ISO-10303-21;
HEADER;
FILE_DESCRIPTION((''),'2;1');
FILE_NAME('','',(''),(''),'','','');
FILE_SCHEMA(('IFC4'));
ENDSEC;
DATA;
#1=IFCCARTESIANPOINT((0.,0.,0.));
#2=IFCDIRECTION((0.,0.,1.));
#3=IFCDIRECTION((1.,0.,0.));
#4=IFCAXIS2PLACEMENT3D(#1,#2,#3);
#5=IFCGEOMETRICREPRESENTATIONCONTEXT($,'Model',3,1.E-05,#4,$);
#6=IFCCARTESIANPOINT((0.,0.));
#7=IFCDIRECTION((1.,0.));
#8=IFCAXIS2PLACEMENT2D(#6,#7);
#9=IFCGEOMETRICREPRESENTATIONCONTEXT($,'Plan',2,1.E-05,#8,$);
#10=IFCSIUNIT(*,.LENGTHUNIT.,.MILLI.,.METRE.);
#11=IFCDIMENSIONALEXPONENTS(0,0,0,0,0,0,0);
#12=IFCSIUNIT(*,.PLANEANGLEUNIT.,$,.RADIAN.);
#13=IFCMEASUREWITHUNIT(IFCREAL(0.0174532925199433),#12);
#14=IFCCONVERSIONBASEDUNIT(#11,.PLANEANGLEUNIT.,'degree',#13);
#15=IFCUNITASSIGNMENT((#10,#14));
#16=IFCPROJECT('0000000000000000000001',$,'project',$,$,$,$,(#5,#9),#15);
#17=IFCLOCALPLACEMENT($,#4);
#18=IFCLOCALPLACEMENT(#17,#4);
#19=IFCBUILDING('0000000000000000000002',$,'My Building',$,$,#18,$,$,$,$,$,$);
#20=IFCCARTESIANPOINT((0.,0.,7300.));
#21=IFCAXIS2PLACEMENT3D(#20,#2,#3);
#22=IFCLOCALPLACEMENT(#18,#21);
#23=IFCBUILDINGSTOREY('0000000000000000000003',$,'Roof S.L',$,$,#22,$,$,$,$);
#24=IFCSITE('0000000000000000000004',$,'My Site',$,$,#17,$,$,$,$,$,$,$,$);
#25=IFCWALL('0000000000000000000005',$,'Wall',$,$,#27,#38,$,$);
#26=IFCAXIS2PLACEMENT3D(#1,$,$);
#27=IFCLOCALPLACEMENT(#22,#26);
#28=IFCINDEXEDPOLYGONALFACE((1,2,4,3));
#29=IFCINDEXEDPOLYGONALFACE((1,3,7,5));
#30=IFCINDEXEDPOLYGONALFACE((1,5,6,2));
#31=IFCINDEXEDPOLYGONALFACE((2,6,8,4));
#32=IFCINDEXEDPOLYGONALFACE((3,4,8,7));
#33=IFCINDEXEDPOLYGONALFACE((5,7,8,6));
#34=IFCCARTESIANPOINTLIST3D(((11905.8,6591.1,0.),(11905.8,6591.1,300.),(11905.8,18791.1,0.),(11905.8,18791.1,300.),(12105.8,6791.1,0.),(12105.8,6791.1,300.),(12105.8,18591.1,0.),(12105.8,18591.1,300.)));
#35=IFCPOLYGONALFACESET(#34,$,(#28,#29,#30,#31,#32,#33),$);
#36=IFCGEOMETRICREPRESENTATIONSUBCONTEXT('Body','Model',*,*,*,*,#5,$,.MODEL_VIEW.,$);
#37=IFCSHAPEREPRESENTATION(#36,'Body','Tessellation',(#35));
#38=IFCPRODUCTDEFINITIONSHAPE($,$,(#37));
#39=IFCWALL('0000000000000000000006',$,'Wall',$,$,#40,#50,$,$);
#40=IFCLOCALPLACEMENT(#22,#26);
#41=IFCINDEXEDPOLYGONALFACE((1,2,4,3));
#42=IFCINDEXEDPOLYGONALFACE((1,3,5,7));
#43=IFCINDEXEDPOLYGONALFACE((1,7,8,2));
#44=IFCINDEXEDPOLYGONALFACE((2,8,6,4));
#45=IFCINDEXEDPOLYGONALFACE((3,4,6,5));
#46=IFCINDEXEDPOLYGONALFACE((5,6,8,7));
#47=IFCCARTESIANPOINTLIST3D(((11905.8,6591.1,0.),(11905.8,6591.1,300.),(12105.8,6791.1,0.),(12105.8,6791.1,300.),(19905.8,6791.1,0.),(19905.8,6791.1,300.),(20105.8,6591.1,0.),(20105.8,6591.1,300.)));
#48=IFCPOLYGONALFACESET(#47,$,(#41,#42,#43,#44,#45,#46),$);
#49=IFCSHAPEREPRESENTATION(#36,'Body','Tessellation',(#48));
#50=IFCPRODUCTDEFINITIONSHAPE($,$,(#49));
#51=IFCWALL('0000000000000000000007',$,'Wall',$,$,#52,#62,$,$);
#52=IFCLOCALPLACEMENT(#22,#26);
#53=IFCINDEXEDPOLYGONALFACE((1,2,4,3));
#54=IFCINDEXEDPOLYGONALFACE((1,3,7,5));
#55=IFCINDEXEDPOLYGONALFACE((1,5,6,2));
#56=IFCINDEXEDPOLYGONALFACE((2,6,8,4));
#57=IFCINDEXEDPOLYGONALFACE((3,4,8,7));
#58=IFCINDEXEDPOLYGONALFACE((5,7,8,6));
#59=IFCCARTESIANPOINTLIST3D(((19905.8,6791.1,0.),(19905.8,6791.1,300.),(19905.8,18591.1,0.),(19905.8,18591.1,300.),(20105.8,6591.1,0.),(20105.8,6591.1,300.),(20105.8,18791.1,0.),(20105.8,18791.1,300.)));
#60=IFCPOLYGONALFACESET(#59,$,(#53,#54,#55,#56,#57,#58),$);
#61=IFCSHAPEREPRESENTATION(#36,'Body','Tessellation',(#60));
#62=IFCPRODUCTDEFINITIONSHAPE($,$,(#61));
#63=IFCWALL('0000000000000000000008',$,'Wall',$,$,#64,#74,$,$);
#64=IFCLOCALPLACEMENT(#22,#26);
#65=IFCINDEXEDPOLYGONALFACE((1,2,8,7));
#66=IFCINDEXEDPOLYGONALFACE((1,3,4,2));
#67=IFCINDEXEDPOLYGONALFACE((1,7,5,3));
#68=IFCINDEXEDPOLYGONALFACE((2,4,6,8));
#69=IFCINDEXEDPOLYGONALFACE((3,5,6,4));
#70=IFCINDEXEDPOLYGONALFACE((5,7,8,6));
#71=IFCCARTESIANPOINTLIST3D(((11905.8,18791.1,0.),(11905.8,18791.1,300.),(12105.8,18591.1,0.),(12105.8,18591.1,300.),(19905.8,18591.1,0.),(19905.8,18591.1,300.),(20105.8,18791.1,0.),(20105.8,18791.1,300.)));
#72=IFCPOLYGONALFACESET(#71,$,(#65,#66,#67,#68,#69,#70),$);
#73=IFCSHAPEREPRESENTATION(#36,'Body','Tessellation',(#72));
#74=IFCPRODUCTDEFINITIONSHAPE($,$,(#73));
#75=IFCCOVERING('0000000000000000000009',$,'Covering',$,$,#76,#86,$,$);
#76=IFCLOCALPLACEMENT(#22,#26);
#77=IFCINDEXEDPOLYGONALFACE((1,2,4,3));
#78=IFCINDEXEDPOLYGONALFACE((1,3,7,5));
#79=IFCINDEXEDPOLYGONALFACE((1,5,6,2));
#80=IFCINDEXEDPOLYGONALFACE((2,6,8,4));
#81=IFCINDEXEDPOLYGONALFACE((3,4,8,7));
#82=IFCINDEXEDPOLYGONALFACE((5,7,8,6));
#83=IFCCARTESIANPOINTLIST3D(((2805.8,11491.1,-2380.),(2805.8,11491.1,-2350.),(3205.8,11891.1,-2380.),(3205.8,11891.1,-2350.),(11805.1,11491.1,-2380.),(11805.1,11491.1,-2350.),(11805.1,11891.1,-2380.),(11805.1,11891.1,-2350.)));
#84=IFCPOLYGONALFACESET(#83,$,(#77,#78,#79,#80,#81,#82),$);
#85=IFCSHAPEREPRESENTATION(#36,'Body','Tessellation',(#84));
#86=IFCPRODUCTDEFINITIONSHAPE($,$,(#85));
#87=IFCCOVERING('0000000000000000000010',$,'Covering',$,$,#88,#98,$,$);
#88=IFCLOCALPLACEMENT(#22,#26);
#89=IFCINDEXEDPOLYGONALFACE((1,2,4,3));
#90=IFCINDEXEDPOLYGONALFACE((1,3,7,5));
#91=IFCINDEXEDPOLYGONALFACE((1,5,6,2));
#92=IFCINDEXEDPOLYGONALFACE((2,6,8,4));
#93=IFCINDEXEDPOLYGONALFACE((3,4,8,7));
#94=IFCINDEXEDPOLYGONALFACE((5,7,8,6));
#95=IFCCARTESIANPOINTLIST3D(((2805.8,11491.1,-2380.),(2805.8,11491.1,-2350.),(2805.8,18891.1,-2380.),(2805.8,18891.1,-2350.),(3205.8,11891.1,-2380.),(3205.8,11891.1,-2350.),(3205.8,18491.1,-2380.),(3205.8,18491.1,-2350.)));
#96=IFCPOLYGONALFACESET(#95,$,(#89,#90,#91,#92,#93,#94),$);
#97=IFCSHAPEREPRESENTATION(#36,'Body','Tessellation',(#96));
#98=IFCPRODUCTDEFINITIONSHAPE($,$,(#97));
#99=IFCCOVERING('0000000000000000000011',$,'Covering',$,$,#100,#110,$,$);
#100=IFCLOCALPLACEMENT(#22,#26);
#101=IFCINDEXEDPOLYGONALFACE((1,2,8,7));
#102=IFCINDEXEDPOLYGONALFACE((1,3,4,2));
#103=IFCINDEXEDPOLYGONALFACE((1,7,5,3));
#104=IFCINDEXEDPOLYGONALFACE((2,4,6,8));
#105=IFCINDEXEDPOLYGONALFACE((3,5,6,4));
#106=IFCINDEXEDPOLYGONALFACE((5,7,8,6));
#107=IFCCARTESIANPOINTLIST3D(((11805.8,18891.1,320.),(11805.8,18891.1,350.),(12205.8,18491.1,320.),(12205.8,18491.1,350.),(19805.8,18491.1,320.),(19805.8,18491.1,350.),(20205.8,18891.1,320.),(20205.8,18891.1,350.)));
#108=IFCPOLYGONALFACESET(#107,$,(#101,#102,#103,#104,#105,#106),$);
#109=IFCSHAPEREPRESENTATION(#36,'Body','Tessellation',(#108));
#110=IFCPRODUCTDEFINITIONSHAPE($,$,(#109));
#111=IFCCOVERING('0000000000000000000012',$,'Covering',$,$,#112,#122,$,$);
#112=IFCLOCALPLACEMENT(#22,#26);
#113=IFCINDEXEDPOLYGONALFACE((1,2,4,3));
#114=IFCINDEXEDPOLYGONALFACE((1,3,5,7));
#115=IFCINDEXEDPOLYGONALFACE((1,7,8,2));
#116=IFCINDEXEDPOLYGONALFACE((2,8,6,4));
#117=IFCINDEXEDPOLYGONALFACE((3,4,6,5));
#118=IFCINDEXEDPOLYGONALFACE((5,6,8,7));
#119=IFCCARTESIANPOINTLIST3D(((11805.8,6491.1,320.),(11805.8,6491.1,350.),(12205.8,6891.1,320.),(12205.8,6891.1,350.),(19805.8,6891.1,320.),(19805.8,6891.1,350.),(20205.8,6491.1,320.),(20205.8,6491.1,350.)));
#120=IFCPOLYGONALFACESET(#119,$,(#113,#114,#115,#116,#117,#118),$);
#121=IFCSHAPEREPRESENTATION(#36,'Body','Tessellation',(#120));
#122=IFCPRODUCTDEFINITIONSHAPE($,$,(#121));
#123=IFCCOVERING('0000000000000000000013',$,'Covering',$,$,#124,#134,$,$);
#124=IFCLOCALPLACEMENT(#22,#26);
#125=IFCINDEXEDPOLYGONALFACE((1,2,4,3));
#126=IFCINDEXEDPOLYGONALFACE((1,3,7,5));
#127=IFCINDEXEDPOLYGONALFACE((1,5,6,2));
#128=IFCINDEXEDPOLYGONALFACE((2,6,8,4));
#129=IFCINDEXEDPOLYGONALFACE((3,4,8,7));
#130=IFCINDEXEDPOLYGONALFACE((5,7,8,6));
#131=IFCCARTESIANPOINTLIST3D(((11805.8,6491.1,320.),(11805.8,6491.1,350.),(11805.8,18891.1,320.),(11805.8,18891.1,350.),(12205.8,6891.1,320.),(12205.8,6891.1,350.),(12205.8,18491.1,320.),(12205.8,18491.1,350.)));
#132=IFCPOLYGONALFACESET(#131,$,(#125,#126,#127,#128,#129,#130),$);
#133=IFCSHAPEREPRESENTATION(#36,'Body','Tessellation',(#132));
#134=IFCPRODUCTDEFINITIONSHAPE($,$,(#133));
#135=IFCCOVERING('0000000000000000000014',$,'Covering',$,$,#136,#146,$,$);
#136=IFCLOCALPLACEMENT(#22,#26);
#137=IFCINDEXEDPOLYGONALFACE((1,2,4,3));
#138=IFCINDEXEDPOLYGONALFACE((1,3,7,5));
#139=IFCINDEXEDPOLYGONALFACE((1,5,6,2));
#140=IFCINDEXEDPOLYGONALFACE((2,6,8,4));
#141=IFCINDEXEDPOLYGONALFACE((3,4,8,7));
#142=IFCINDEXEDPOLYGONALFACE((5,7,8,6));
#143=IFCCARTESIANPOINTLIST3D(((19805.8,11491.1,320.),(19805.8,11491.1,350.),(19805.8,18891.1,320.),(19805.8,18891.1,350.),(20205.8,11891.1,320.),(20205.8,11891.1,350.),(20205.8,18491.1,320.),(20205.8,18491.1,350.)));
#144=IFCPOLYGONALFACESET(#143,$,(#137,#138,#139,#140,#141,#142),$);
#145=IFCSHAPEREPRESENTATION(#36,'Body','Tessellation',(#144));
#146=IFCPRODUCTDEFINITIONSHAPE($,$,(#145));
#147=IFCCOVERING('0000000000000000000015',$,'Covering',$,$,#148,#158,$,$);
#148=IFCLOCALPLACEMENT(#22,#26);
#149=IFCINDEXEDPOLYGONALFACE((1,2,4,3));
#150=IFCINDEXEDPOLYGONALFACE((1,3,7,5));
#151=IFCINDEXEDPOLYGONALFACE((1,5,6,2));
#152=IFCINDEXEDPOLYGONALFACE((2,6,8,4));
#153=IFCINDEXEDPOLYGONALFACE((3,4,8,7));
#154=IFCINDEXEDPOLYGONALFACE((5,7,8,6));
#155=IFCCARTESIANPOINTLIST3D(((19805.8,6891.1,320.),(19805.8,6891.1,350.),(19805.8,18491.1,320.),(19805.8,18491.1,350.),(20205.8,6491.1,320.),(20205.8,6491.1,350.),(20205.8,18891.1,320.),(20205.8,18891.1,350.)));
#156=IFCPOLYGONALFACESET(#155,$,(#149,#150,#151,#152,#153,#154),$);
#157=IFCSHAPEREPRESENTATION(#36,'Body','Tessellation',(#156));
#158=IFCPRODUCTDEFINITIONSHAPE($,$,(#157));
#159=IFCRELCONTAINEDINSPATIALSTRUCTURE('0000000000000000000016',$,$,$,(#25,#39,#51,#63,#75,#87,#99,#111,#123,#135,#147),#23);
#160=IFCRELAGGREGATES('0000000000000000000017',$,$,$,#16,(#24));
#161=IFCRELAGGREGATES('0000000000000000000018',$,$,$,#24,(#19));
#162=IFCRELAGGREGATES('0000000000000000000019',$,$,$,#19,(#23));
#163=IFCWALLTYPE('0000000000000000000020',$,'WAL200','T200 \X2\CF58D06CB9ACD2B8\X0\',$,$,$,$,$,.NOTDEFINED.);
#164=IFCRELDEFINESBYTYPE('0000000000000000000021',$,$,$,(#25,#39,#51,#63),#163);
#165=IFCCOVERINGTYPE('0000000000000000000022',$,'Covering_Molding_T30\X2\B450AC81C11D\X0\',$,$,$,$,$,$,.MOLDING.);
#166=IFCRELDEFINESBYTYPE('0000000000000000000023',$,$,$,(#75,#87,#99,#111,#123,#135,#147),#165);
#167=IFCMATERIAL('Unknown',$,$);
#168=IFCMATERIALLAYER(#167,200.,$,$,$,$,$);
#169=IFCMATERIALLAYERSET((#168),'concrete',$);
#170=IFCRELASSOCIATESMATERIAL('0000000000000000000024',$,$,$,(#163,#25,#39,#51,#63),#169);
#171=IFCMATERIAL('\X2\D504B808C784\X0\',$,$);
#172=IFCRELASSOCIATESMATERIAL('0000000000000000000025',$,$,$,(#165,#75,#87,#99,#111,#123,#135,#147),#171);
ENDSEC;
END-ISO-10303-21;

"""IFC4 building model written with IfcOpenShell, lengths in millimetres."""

from ifc_helpers import new_model, entity, si_unit, converted_unit, frame, origin_with_axes, origin_2d_with_axis, place, context, subcontext, project, spatial, indexed_curve, rectangle, outline, extrude, clip, halfspace, material, layer, layer_set, layer_usage, material_profile, profile_set, profile_usage, type_object, element, save


model = new_model("IFC4")

# Units and contexts
model_context = context("Model", 3, precision=1e-05, world=origin_with_axes())
plan_context = context("Plan", 2, precision=1e-05, world=origin_2d_with_axis())
body_context = subcontext(model_context, "Body", "Model", "MODEL_VIEW")
ifc_project = project(units=[si_unit("LENGTHUNIT", "METRE", prefix="MILLI"), converted_unit("PLANEANGLEUNIT", "degree", entity("IfcReal", 0.0174532925199433), si_unit("PLANEANGLEUNIT", "RADIAN"), dimensions=[0, 0, 0, 0, 0, 0, 0])], contexts=[model_context, plan_context])

# Site, building, storey
site_placement = place(None, origin_with_axes())
site = spatial("IfcSite", under=ifc_project, at=site_placement, Name="My Site")
building_placement = place(site_placement, origin_with_axes())
building = spatial("IfcBuilding", under=site, at=building_placement, Name="My Building")
storey_placement = place(building_placement, frame((0.0, 0.0, 7300.0), z_axis=(0.0, 0.0, 1.0), x_axis=(1.0, 0.0, 0.0)))
storey = spatial("IfcBuildingStorey", under=building, at=storey_placement, Name="Roof S.L")

# Walls
ifc_material_1 = material(Name="Unknown")
ifc_layer = layer(ifc_material_1, 200.0)
ifc_layer_set = layer_set([ifc_layer], Name="concrete")
ifc_layer_usage_1 = layer_usage(ifc_layer_set, "AXIS2", "POSITIVE", 0.0)
wall_type = type_object("IfcWallType", Name="WAL200", Description="T200 콘크리트", PredefinedType="NOTDEFINED", material=ifc_layer_set)
wall_1_placement = place(storey_placement, frame((11905.8, 18791.1, 0.0), z_axis=(0.0, 0.0, 1.0), x_axis=(0.0, -1.0, 0.0)))
element("IfcWall", 1, at=wall_1_placement, inside=storey, type_object=wall_type, material=ifc_layer_usage_1, Name="Wall", context=body_context, shape_type="Clipping", body=[
    clip(clip(extrude(outline(indexed_curve([(0.0, 0.0), (0.0, 200.0), (12200.0, 200.0), (12200.0, 0.0), (0.0, 0.0)], self_intersect=False)), origin_with_axes(), (0.0, 0.0, 1.0), 300.0), halfspace(frame((12200.0, 0.0, -7300.0), z_axis=(0.707107, 0.707107, 0.0), x_axis=(0.707107, -0.707107, 0.0)), False)), halfspace(frame((0.0, 0.0, -7300.0), z_axis=(-0.707105, 0.707109, 0.0), x_axis=(0.707109, 0.707105, 0.0)), False)),
])
ifc_layer_usage_2 = layer_usage(ifc_layer_set, "AXIS2", "POSITIVE", 0.0)
wall_2_placement = place(storey_placement, frame((11905.8, 6591.1, 0.0), z_axis=(0.0, 0.0, 1.0), x_axis=(1.0, 0.0, 0.0)))
element("IfcWall", 2, at=wall_2_placement, inside=storey, type_object=wall_type, material=ifc_layer_usage_2, Name="Wall", context=body_context, shape_type="Clipping", body=[
    clip(clip(extrude(outline(indexed_curve([(0.0, 0.0), (0.0, 200.0), (8200.0, 200.0), (8200.0, 0.0), (0.0, 0.0)], self_intersect=False)), origin_with_axes(), (0.0, 0.0, 1.0), 300.0), halfspace(frame((8200.0, 0.0, -7300.0), z_axis=(0.707105, 0.707108, 0.0), x_axis=(0.707108, -0.707105, 0.0)), False)), halfspace(frame((0.0, 0.0, -7300.0), z_axis=(-0.707106, 0.707107, 0.0), x_axis=(0.707107, 0.707107, 0.0)), False)),
])
ifc_layer_usage_3 = layer_usage(ifc_layer_set, "AXIS2", "POSITIVE", 0.0)
wall_3_placement = place(storey_placement, frame((20105.8, 6591.1, 0.0), z_axis=(0.0, 0.0, 1.0), x_axis=(0.0, 1.0, 0.0)))
element("IfcWall", 3, at=wall_3_placement, inside=storey, type_object=wall_type, material=ifc_layer_usage_3, Name="Wall", context=body_context, shape_type="Clipping", body=[
    clip(clip(extrude(outline(indexed_curve([(0.0, 0.0), (0.0, 200.0), (12200.0, 200.0), (12200.0, 0.0), (0.0, 0.0)], self_intersect=False)), origin_with_axes(), (0.0, 0.0, 1.0), 300.0), halfspace(frame((12200.0, 0.0, -7300.0), z_axis=(0.707106, 0.707107, 0.0), x_axis=(0.707107, -0.707107, 0.0)), False)), halfspace(frame((0.0, 0.0, -7300.0), z_axis=(-0.707109, 0.707105, 0.0), x_axis=(0.707105, 0.707109, 0.0)), False)),
])
ifc_layer_usage_4 = layer_usage(ifc_layer_set, "AXIS2", "POSITIVE", 0.0)
wall_4_placement = place(storey_placement, frame((20105.8, 18791.1, 0.0), z_axis=(0.0, 0.0, 1.0), x_axis=(-1.0, 0.0, 0.0)))
element("IfcWall", 4, at=wall_4_placement, inside=storey, type_object=wall_type, material=ifc_layer_usage_4, Name="Wall", context=body_context, shape_type="Clipping", body=[
    clip(clip(extrude(outline(indexed_curve([(0.0, 0.0), (0.0, 200.0), (8200.0, 200.0), (8200.0, 0.0), (0.0, 0.0)], self_intersect=False)), origin_with_axes(), (0.0, 0.0, 1.0), 300.0), halfspace(frame((8200.0, 0.0, -7300.0), z_axis=(0.707108, 0.707105, 0.0), x_axis=(0.707105, -0.707108, 0.0)), False)), halfspace(frame((0.0, 0.0, -7300.0), z_axis=(-0.707107, 0.707107, 0.0), x_axis=(0.707107, 0.707107, 0.0)), False)),
])

# Coverings
ifc_material_2 = material(Name="프레임")
ifc_material_profile = material_profile(ifc_material_2, rectangle(XDim=400.0, YDim=30.0, kind="CURVE"))
ifc_profile_set = profile_set([ifc_material_profile])
ifc_profile_usage_1 = profile_usage(ifc_profile_set, cardinal=5)
covering_type = type_object("IfcCoveringType", Name="Covering_Molding_T30두겁석", PredefinedType="MOLDING", material=ifc_profile_set)
covering_1_placement = place(storey_placement, frame((2805.8, 11691.1, -2365.0), z_axis=(1.0, 0.0, 0.0), x_axis=(0.0, 1.0, 0.0)))
element("IfcCovering", 5, at=covering_1_placement, inside=storey, type_object=covering_type, material=ifc_profile_usage_1, Name="Covering", context=body_context, shape_type="Clipping", body=[
    clip(extrude(rectangle(XDim=400.0, YDim=30.0, kind="CURVE"), origin_with_axes(), (0.0, 0.0, 1.0), 8999.3), halfspace(frame((-200.0, -4915.0, 0.0), z_axis=(0.707108, 0.0, -0.707106), x_axis=(0.0, -1.0, 0.0)), False)),
])
ifc_profile_usage_2 = profile_usage(ifc_profile_set, cardinal=5)
covering_2_placement = place(storey_placement, frame((3005.8, 11491.1, -2365.0), z_axis=(0.0, 1.0, 0.0), x_axis=(-1.0, 0.0, 0.0)))
element("IfcCovering", 6, at=covering_2_placement, inside=storey, type_object=covering_type, material=ifc_profile_usage_2, Name="Covering", context=body_context, shape_type="Clipping", body=[
    clip(clip(extrude(rectangle(XDim=400.0, YDim=30.0, kind="CURVE"), origin_with_axes(), (0.0, 0.0, 1.0), 7400.0), halfspace(frame((200.0, -4915.0, 0.0), z_axis=(-0.707106, 0.0, -0.707107), x_axis=(0.0, 1.0, 0.0)), False)), halfspace(frame((200.0, -4915.0, 7400.0), z_axis=(-0.707108, 0.0, 0.707106), x_axis=(0.0, 1.0, 0.0)), False)),
])
ifc_profile_usage_3 = profile_usage(ifc_profile_set, cardinal=5)
covering_3_placement = place(storey_placement, frame((11805.8, 18691.1, 335.0), z_axis=(1.0, 0.0, 0.0), x_axis=(0.0, 1.0, 0.0)))
element("IfcCovering", 7, at=covering_3_placement, inside=storey, type_object=covering_type, material=ifc_profile_usage_3, Name="Covering", context=body_context, shape_type="Clipping", body=[
    clip(clip(extrude(rectangle(XDim=400.0, YDim=30.0, kind="CURVE"), origin_with_axes(), (0.0, 0.0, 1.0), 8400.0), halfspace(frame((200.0, -7635.0, 0.0), z_axis=(-0.707106, 0.0, -0.707108), x_axis=(0.0, 1.0, 0.0)), False)), halfspace(frame((200.0, -7635.0, 8400.0), z_axis=(-0.707107, 0.0, 0.707107), x_axis=(0.0, 1.0, 0.0)), False)),
])
ifc_profile_usage_4 = profile_usage(ifc_profile_set, cardinal=5)
covering_4_placement = place(storey_placement, frame((11805.8, 6691.1, 335.0), z_axis=(1.0, 0.0, 0.0), x_axis=(0.0, 1.0, 0.0)))
element("IfcCovering", 8, at=covering_4_placement, inside=storey, type_object=covering_type, material=ifc_profile_usage_4, Name="Covering", context=body_context, shape_type="Clipping", body=[
    clip(clip(extrude(rectangle(XDim=400.0, YDim=30.0, kind="CURVE"), origin_with_axes(), (0.0, 0.0, 1.0), 8400.0), halfspace(frame((-200.0, -7635.0, 8400.0), z_axis=(0.707109, 0.0, 0.707105), x_axis=(0.0, -1.0, 0.0)), False)), halfspace(frame((-200.0, -7635.0, 0.0), z_axis=(0.707108, 0.0, -0.707106), x_axis=(0.0, -1.0, 0.0)), False)),
])
ifc_profile_usage_5 = profile_usage(ifc_profile_set, cardinal=5)
covering_5_placement = place(storey_placement, frame((12005.8, 6491.1, 335.0), z_axis=(0.0, 1.0, 0.0), x_axis=(-1.0, 0.0, 0.0)))
element("IfcCovering", 9, at=covering_5_placement, inside=storey, type_object=covering_type, material=ifc_profile_usage_5, Name="Covering", context=body_context, shape_type="Clipping", body=[
    clip(clip(extrude(rectangle(XDim=400.0, YDim=30.0, kind="CURVE"), origin_with_axes(), (0.0, 0.0, 1.0), 12400.0), halfspace(frame((200.0, -7635.0, 0.0), z_axis=(-0.707106, 0.0, -0.707107), x_axis=(0.0, 1.0, 0.0)), False)), halfspace(frame((200.0, -7635.0, 12400.0), z_axis=(-0.707108, 0.0, 0.707106), x_axis=(0.0, 1.0, 0.0)), False)),
])
ifc_profile_usage_6 = profile_usage(ifc_profile_set, cardinal=5)
covering_6_placement = place(storey_placement, frame((20005.8, 11491.1, 335.0), z_axis=(0.0, 1.0, 0.0), x_axis=(-1.0, 0.0, 0.0)))
element("IfcCovering", 10, at=covering_6_placement, inside=storey, type_object=covering_type, material=ifc_profile_usage_6, Name="Covering", context=body_context, shape_type="Clipping", body=[
    clip(clip(extrude(rectangle(XDim=400.0, YDim=30.0, kind="CURVE"), origin_with_axes(), (0.0, 0.0, 1.0), 7400.0), halfspace(frame((200.0, -4915.0, 0.0), z_axis=(-0.707106, 0.0, -0.707107), x_axis=(0.0, 1.0, 0.0)), False)), halfspace(frame((200.0, -4915.0, 7400.0), z_axis=(-0.707108, 0.0, 0.707106), x_axis=(0.0, 1.0, 0.0)), False)),
])
ifc_profile_usage_7 = profile_usage(ifc_profile_set, cardinal=5)
covering_7_placement = place(storey_placement, frame((20005.8, 6491.1, 335.0), z_axis=(0.0, 1.0, 0.0), x_axis=(-1.0, 0.0, 0.0)))
element("IfcCovering", 11, at=covering_7_placement, inside=storey, type_object=covering_type, material=ifc_profile_usage_7, Name="Covering", context=body_context, shape_type="Clipping", body=[
    clip(clip(extrude(rectangle(XDim=400.0, YDim=30.0, kind="CURVE"), origin_with_axes(), (0.0, 0.0, 1.0), 12400.0), halfspace(frame((-200.0, -7635.0, 0.0), z_axis=(0.707105, 0.0, -0.707109), x_axis=(0.0, -1.0, 0.0)), False)), halfspace(frame((-200.0, -7635.0, 12400.0), z_axis=(0.707107, 0.0, 0.707107), x_axis=(0.0, -1.0, 0.0)), False)),
])

save(model, "model.ifc")
